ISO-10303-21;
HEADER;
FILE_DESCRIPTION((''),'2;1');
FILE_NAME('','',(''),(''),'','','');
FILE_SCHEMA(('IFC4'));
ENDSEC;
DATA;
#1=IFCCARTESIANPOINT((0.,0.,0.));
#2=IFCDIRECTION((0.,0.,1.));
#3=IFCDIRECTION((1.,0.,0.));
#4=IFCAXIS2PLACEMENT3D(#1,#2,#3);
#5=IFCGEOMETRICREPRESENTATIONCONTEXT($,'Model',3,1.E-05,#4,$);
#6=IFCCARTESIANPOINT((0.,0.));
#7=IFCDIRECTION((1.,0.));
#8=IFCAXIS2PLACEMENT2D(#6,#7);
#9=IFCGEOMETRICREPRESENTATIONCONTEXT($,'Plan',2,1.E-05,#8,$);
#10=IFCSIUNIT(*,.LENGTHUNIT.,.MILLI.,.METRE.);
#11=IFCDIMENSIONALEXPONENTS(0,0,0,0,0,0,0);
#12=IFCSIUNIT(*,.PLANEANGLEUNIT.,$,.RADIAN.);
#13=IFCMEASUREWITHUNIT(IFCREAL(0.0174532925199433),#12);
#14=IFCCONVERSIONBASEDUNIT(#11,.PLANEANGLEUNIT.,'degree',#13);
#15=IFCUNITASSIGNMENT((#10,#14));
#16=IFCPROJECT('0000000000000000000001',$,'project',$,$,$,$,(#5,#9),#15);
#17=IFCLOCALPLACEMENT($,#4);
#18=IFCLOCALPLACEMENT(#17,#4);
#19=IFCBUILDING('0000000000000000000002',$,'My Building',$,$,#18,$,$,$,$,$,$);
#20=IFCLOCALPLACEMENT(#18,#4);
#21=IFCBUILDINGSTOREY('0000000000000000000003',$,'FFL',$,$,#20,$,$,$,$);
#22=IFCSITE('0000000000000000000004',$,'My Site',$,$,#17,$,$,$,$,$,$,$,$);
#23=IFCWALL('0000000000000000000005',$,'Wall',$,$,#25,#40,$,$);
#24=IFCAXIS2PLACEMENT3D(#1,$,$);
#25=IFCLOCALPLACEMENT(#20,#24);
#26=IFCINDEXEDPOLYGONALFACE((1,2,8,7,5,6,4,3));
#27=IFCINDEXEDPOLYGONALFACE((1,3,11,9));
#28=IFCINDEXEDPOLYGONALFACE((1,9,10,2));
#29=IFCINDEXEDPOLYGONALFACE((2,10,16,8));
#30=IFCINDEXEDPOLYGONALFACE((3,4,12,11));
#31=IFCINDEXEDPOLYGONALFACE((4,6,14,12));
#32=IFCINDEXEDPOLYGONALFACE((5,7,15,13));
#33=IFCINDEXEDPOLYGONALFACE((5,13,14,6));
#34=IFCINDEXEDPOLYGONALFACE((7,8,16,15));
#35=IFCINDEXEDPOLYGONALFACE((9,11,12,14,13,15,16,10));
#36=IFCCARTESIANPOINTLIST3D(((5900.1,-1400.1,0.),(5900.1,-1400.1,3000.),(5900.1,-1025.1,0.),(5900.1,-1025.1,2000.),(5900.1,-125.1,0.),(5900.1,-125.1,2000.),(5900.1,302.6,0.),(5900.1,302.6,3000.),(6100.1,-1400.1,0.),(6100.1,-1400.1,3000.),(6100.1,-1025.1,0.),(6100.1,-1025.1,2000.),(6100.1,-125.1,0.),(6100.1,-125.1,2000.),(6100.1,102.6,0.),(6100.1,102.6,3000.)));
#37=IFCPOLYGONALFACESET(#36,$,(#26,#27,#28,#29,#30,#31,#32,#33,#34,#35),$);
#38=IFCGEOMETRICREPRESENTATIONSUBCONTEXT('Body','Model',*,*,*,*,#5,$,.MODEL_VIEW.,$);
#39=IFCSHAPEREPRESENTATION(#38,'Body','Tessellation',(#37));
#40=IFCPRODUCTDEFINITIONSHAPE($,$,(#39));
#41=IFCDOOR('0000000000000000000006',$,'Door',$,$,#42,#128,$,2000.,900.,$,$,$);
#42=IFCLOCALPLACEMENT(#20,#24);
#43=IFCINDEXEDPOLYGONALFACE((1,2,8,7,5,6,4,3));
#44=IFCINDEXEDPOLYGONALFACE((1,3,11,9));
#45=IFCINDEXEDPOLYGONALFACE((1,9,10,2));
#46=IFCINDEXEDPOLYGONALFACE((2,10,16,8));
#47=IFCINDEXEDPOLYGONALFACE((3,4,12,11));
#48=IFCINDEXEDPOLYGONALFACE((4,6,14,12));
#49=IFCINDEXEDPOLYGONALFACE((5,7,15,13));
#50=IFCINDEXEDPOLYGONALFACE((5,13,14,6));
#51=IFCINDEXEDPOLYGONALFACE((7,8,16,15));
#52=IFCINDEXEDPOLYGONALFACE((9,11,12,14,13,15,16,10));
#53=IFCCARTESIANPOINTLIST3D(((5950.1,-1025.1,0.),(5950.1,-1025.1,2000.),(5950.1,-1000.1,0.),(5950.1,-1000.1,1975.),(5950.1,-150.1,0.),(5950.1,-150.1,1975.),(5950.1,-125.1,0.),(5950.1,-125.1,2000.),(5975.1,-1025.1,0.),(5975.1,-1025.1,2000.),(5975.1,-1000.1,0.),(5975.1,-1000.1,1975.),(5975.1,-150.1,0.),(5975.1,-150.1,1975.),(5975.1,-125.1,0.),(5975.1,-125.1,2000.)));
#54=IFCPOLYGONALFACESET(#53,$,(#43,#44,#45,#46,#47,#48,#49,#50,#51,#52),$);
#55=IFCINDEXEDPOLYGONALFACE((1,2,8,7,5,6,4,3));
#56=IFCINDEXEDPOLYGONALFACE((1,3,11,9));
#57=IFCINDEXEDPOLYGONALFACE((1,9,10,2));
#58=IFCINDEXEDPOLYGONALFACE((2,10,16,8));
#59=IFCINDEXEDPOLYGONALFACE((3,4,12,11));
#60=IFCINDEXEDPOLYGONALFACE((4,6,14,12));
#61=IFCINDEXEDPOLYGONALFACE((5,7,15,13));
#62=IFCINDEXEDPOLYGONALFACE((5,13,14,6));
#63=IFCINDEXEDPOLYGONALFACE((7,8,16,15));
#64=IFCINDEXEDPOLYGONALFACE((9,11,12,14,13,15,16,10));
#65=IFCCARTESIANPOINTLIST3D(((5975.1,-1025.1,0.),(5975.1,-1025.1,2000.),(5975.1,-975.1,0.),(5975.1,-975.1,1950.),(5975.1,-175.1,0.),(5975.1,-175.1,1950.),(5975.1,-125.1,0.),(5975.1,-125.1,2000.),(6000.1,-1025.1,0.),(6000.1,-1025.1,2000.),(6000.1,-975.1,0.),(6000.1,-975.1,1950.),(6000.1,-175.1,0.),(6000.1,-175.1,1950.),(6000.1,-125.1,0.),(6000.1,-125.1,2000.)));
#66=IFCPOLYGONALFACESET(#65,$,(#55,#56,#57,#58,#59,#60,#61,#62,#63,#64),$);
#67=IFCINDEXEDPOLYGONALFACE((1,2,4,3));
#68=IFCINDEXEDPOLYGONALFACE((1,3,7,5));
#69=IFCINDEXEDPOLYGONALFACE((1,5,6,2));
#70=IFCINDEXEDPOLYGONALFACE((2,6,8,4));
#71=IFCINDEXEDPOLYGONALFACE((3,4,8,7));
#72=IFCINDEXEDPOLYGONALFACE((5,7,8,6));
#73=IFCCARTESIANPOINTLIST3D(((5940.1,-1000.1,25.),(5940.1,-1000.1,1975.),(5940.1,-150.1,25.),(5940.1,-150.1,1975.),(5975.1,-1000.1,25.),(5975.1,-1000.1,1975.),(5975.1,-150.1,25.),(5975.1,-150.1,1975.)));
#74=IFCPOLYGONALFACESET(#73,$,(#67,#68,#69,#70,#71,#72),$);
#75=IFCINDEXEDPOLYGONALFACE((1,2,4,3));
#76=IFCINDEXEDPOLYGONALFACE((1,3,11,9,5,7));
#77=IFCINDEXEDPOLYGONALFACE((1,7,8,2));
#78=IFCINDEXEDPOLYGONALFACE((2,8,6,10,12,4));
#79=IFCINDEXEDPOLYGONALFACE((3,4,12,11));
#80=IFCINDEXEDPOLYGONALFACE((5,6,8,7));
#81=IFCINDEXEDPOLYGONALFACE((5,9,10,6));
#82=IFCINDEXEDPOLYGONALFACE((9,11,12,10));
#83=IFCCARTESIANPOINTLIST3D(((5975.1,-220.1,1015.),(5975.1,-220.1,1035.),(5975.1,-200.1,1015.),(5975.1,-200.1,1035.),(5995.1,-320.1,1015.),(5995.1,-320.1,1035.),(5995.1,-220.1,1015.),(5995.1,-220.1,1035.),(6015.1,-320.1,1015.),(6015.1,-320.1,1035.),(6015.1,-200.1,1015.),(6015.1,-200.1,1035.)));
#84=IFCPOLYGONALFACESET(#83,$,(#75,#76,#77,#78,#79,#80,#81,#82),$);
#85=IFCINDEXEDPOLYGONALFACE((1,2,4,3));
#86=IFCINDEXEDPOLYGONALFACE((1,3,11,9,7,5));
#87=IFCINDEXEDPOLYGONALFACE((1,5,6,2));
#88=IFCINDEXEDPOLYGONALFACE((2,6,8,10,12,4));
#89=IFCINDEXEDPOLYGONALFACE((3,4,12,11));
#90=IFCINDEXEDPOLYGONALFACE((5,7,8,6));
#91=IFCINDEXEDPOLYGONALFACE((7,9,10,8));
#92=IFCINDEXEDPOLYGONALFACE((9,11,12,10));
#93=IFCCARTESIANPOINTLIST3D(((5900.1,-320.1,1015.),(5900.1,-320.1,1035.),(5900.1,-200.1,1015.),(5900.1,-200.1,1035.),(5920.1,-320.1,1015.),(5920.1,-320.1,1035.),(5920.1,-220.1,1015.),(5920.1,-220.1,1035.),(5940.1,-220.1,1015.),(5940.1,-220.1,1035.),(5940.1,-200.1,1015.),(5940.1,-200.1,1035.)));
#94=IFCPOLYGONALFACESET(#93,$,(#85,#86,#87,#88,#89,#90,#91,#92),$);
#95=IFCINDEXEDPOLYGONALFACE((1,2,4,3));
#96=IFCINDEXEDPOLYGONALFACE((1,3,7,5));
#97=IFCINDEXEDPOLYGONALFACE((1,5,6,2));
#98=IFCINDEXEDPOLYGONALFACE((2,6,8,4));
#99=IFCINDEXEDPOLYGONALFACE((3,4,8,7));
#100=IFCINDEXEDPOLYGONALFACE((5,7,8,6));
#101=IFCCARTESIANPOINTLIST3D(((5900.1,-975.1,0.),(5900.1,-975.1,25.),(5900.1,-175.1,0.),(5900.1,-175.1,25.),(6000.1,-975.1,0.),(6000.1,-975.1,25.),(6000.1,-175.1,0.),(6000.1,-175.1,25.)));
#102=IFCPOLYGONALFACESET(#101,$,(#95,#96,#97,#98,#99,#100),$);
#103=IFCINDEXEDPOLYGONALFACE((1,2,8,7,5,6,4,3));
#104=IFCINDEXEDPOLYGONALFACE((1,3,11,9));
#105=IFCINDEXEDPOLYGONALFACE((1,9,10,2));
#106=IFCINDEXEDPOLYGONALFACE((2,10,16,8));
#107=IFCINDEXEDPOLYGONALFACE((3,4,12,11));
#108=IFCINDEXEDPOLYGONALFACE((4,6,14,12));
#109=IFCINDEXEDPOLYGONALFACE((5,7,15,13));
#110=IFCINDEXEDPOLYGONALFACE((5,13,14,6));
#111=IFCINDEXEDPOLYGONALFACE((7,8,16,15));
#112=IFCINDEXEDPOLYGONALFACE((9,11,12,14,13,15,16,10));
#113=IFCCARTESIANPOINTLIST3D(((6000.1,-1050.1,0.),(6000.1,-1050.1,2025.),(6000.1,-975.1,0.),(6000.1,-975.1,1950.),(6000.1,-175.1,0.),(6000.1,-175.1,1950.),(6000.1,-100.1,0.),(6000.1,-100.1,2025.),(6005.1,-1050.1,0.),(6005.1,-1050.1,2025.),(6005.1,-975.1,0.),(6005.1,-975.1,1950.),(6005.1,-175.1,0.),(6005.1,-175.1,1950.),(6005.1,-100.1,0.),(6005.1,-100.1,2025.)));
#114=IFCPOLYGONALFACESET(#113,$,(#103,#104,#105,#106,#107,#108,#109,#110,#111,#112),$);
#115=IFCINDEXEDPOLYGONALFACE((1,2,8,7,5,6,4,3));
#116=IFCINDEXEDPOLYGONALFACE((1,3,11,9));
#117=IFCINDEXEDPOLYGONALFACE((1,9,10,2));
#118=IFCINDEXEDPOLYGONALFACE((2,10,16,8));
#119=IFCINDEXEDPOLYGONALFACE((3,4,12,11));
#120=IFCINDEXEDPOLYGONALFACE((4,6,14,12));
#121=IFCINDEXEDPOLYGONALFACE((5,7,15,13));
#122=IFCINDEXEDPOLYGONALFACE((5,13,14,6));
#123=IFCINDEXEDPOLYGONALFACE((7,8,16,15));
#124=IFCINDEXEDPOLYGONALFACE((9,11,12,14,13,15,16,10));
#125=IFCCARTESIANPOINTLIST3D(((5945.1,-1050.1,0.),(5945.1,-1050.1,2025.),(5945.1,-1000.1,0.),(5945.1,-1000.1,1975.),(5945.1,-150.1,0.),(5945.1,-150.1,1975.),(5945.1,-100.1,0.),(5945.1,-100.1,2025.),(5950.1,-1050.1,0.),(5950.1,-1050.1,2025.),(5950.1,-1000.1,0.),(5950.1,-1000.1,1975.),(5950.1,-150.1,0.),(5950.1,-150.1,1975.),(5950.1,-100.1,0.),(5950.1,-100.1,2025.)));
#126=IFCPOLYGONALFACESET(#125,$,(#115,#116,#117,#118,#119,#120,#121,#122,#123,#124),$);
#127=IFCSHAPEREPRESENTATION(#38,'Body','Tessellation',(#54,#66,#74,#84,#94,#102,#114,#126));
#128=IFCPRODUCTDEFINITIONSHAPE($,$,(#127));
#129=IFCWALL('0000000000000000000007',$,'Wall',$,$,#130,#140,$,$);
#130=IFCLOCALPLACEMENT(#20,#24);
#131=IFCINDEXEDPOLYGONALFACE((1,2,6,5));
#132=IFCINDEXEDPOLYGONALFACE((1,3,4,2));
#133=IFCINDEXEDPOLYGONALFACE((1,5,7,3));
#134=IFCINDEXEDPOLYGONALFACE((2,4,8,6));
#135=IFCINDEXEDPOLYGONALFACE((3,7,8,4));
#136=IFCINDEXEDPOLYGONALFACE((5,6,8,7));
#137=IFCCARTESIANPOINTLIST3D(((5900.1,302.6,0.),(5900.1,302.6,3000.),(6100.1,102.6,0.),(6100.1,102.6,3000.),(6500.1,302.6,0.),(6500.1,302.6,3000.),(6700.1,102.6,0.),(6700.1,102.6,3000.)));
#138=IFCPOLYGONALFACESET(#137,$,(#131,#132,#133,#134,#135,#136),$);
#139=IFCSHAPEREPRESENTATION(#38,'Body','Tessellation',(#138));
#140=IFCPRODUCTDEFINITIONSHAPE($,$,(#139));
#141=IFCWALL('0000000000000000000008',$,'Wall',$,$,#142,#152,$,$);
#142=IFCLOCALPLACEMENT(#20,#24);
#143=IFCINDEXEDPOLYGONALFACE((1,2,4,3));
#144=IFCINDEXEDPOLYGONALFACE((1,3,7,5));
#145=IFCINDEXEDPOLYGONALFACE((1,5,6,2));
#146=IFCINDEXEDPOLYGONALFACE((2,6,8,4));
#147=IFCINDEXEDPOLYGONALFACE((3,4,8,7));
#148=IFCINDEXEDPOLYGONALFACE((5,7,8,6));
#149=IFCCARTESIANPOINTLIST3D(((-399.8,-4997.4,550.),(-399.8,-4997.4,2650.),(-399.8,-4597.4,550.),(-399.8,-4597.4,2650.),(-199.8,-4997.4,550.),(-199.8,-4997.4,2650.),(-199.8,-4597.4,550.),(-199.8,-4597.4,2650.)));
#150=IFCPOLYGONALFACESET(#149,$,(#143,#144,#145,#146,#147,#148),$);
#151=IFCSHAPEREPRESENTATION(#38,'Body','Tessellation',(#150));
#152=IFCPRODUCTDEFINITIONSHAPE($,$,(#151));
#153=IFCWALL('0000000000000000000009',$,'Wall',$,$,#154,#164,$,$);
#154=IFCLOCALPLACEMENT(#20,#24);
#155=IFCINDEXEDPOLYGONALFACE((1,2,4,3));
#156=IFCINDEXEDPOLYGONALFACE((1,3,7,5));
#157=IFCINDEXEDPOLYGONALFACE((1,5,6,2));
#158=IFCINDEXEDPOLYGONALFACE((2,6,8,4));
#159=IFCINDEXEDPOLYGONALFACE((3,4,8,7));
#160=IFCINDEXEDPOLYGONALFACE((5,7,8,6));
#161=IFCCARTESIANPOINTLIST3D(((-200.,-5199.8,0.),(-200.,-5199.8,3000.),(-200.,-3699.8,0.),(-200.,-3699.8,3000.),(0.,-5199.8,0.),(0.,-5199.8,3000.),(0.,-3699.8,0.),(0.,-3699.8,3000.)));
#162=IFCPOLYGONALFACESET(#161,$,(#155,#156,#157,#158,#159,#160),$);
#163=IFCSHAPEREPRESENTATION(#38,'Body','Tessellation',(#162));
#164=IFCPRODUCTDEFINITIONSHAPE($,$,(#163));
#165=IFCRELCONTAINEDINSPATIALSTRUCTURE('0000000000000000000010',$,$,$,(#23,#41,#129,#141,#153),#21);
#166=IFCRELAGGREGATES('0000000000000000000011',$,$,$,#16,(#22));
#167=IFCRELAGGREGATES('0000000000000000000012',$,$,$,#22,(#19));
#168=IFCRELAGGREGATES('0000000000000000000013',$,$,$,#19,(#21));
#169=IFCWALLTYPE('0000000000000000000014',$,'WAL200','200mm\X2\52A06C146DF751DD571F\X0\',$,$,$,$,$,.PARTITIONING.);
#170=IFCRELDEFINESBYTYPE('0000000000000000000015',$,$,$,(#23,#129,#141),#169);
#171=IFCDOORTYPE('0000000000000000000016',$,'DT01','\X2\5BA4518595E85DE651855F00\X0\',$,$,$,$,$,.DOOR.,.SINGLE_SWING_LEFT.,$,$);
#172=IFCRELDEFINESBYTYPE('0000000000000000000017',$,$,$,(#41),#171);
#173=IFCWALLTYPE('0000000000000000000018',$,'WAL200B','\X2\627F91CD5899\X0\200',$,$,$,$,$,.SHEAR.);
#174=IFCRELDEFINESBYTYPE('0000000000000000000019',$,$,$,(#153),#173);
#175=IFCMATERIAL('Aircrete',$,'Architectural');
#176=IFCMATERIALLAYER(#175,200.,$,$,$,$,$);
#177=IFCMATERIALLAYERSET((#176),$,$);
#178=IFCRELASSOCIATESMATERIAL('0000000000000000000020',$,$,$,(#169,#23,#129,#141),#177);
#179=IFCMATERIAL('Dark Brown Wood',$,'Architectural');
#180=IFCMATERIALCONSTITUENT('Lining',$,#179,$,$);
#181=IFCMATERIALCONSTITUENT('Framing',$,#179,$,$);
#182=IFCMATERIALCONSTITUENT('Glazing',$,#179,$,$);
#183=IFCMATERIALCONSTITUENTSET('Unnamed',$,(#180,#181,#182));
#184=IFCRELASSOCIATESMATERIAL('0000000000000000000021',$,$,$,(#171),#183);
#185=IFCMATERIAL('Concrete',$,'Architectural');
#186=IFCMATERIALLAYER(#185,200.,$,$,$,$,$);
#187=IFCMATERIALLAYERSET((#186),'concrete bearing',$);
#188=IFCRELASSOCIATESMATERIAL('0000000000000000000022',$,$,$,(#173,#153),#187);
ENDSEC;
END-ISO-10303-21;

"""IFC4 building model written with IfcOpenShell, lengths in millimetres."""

from ifc_helpers import new_model, entity, si_unit, converted_unit, frame, origin_with_axes, origin_2d_with_axis, place, context, subcontext, project, spatial, line, indexed_curve, outline, extrude, shape, source, transform, mapped, material, layer, layer_set, layer_usage, constituent, constituent_set, type_object, type_shapes, element, fill, save


model = new_model("IFC4")

# Units and contexts
model_context = context("Model", 3, precision=1e-05, world=origin_with_axes())
plan_context = context("Plan", 2, precision=1e-05, world=origin_2d_with_axis())
body_context_1 = subcontext(model_context, "Body", "Model", "MODEL_VIEW")
body_context_2 = subcontext(plan_context, "Body", "Plan", "PLAN_VIEW")
ifc_project = project(units=[si_unit("LENGTHUNIT", "METRE", prefix="MILLI"), converted_unit("PLANEANGLEUNIT", "degree", entity("IfcReal", 0.0174532925199433), si_unit("PLANEANGLEUNIT", "RADIAN"), dimensions=[0, 0, 0, 0, 0, 0, 0])], contexts=[model_context, plan_context])

# Site, building, storey
site_placement = place(None, origin_with_axes())
site = spatial("IfcSite", under=ifc_project, at=site_placement, Name="My Site")
building_placement = place(site_placement, origin_with_axes())
building = spatial("IfcBuilding", under=site, at=building_placement, Name="My Building")
storey_placement = place(building_placement, origin_with_axes())
storey = spatial("IfcBuildingStorey", under=building, at=storey_placement, Name="FFL")

# Shared definitions
ifc_material_1 = material(Name="Aircrete", Category="Architectural")

# Shared definitions
ifc_layer_1 = layer(ifc_material_1, 200.0)
ifc_layer_set_1 = layer_set([ifc_layer_1])
wall_type_1 = type_object("IfcWallType", Name="WAL200", Description="200mm加气混凝土", PredefinedType="PARTITIONING", material=ifc_layer_set_1)

# Wall, opening, door
ifc_layer_usage_1 = layer_usage(ifc_layer_set_1, "AXIS2", "NEGATIVE", 0.0)
wall_1_placement = place(storey_placement, frame((5900.1, -1400.1, 0.0), z_axis=(0.0, 0.0, 1.0), x_axis=(0.0, 1.0, 0.0)))
wall_1 = element("IfcWall", 1, at=wall_1_placement, inside=storey, type_object=wall_type_1, material=ifc_layer_usage_1, Name="Wall", context=body_context_1, shape_type="SweptSolid", body=[
    extrude(outline(indexed_curve([(0.0, -200.0), (0.0, 0.0), (1702.7, 0.0), (1502.7, -200.0)], segments=[line(1, 2, 3, 4, 1)])), origin_with_axes(), (0.0, 0.0, 1.0), 3000.0),
])
shared_shape_1 = source(origin_with_axes(), body_context_1, "Body", "SweptSolid", [
    extrude(outline(indexed_curve([(0.0, 0.0), (900.0, 0.0), (900.0, 2000.0), (0.0, 2000.0)], segments=[line(1, 2, 3, 4, 1)])), frame((0.0, -600.0, 0.0), z_axis=(0.0, -1.0, 0.0), x_axis=(1.0, 0.0, 0.0)), (0.0, 0.0, -1.0), 1200.0),
])
opening_1_placement = place(wall_1_placement, frame((375.0, -100.0, 0.0), z_axis=(0.0, 0.0, 1.0), x_axis=(1.0, 0.0, 0.0)))
opening_1 = element("IfcOpeningElement", 2, at=opening_1_placement, cuts=wall_1, PredefinedType="OPENING", context=body_context_1, shape_type="MappedRepresentation", body=[
    mapped(shared_shape_1, transform((0.0, 0.0, 0.0), x_axis=(1.0, 0.0, 0.0), y_axis=(0.0, 1.0, 0.0), z_axis=(0.0, 0.0, 1.0), scale=1.0)),
])
ifc_material_2 = material(Name="Dark Brown Wood", Category="Architectural")
ifc_constituent_1 = constituent(ifc_material_2, Name="Lining")
ifc_constituent_2 = constituent(ifc_material_2, Name="Framing")
ifc_constituent_3 = constituent(ifc_material_2, Name="Glazing")
ifc_constituent_set_1 = constituent_set(constituents=[ifc_constituent_1, ifc_constituent_2, ifc_constituent_3], Name="Unnamed")
door_type = type_object("IfcDoorType", Name="DT01", Description="室内门左内开", OperationType="SINGLE_SWING_LEFT", PredefinedType="DOOR", material=ifc_constituent_set_1)
shared_shape_2 = source(origin_with_axes(), body_context_1, "Body", "SweptSolid", [
    extrude(outline(indexed_curve([(0.0, 0.0), (0.0, 2000.0), (900.0, 2000.0), (900.0, 0.0), (875.0, 0.0), (875.0, 1975.0), (25.0, 1975.0), (25.0, 0.0)], segments=[line(1, 2, 3, 4, 5, 6, 7, 8, 1)])), frame((0.0, 25.0, 0.0), z_axis=(0.0, -1.0, 0.0), x_axis=(1.0, 0.0, 0.0)), (0.0, 0.0, -1.0), 25.0),
    extrude(outline(indexed_curve([(0.0, 0.0), (0.0, 2000.0), (900.0, 2000.0), (900.0, 0.0), (850.0, 0.0), (850.0, 1950.0), (50.0, 1950.0), (50.0, 0.0)], segments=[line(1, 2, 3, 4, 5, 6, 7, 8, 1)])), frame((0.0, 0.0, 0.0), z_axis=(0.0, -1.0, 0.0), x_axis=(1.0, 0.0, 0.0)), (0.0, 0.0, -1.0), 25.0),
    extrude(outline(indexed_curve([(0.0, 0.0), (850.0, 0.0), (850.0, 35.0), (0.0, 35.0)], segments=[line(1, 2, 3, 4, 1)])), frame((25.0, 25.0, 25.0), z_axis=(0.0, 0.0, 1.0), x_axis=(1.0, 0.0, 0.0)), (0.0, 0.0, 1.0), 1950.0),
    extrude(outline(indexed_curve([(0.0, 0.0), (0.0, -40.0), (-120.0, -40.0), (-120.0, -20.0), (-20.0, -20.0), (-20.0, 0.0)], segments=[line(1, 2, 3, 4, 5, 6, 1)])), frame((825.0, 25.0, 1015.0), z_axis=(0.0, 0.0, 1.0), x_axis=(1.0, 0.0, 0.0)), (0.0, 0.0, 1.0), 20.0),
    extrude(outline(indexed_curve([(0.0, 0.0), (0.0, 40.0), (-120.0, 40.0), (-120.0, 20.0), (-20.0, 20.0), (-20.0, 0.0)], segments=[line(1, 2, 3, 4, 5, 6, 1)])), frame((825.0, 60.0, 1015.0), z_axis=(0.0, 0.0, 1.0), x_axis=(1.0, 0.0, 0.0)), (0.0, 0.0, 1.0), 20.0),
    extrude(outline(indexed_curve([(0.0, 0.0), (800.0, 0.0), (800.0, 100.0), (0.0, 100.0)], segments=[line(1, 2, 3, 4, 1)])), frame((50.0, 0.0, 0.0), z_axis=(0.0, 0.0, 1.0), x_axis=(1.0, 0.0, 0.0)), (0.0, 0.0, 1.0), 25.0),
    extrude(outline(indexed_curve([(0.0, 0.0), (0.0, 2025.0), (950.0, 2025.0), (950.0, 0.0), (875.0, 0.0), (875.0, 1950.0), (75.0, 1950.0), (75.0, 0.0)], segments=[line(1, 2, 3, 4, 5, 6, 7, 8, 1)])), frame((-25.0, -5.0, 0.0), z_axis=(0.0, -1.0, 0.0), x_axis=(1.0, 0.0, 0.0)), (0.0, 0.0, -1.0), 5.0),
    extrude(outline(indexed_curve([(0.0, 0.0), (0.0, 2025.0), (950.0, 2025.0), (950.0, 0.0), (900.0, 0.0), (900.0, 1975.0), (50.0, 1975.0), (50.0, 0.0)], segments=[line(1, 2, 3, 4, 5, 6, 7, 8, 1)])), frame((-25.0, 50.0, 0.0), z_axis=(0.0, -1.0, 0.0), x_axis=(1.0, 0.0, 0.0)), (0.0, 0.0, -1.0), 5.0),
])
shared_shape_3 = source(origin_with_axes(), body_context_2, "Body", "Curve2D", [
    entity("IfcIndexedPolyCurve", entity("IfcCartesianPointList2D", [[0.0, 0.0], [0.0, 50.0], [25.0, 50.0], [25.0, 25.0], [50.0, 25.0], [50.0, 0.0]]), [entity("IfcLineIndex", [1, 2, 3, 4, 5, 6, 1])]),
    entity("IfcIndexedPolyCurve", entity("IfcCartesianPointList2D", [[900.0, 0.0], [900.0, 50.0], [875.0, 50.0], [875.0, 25.0], [850.0, 25.0], [850.0, 0.0]]), [entity("IfcLineIndex", [1, 2, 3, 4, 5, 6, 1])]),
    entity("IfcTrimmedCurve", entity("IfcEllipse", entity("IfcAxis2Placement2D", entity("IfcCartesianPoint", [60.0, 50.0]), entity("IfcDirection", [1.0, 0.0])), 815.0, 850.0), [entity("IfcCartesianPoint", [875.0, 50.0])], [entity("IfcCartesianPoint", [60.0, 900.0])], True, "CARTESIAN"),
    entity("IfcIndexedPolyCurve", entity("IfcCartesianPointList2D", [[25.0, 50.0], [60.0, 50.0], [60.0, 900.0], [25.0, 900.0]]), [entity("IfcLineIndex", [1, 2, 3, 4, 1])]),
])
type_shapes(door_type, [shared_shape_2, shared_shape_3])
door_placement = place(opening_1_placement, frame((0.0, 0.0, 0.0), z_axis=(0.0, 0.0, 1.0), x_axis=(1.0, 0.0, 0.0)))
door = element("IfcDoor", 3, at=door_placement, inside=storey, type_object=door_type, Name="Door", OverallHeight=2000.0, OverallWidth=900.0, shapes=[
    shape(body_context_1, "Body", "MappedRepresentation", [mapped(shared_shape_2, transform((0.0, 0.0, 0.0), x_axis=(1.0, 0.0, 0.0), y_axis=(0.0, 1.0, 0.0), z_axis=(0.0, 0.0, 1.0), scale=1.0))]),
    shape(body_context_2, "Body", "MappedRepresentation", [mapped(shared_shape_3, transform((0.0, 0.0, 0.0), x_axis=(1.0, 0.0, 0.0), y_axis=(0.0, 1.0, 0.0), z_axis=(0.0, 0.0, 1.0), scale=1.0))]),
])
fill(opening_1, door)

# Walls
ifc_layer_usage_2 = layer_usage(ifc_layer_set_1, "AXIS2", "NEGATIVE", 0.0)
wall_2_placement = place(storey_placement, frame((5900.1, 302.6, 0.0), z_axis=(0.0, 0.0, 1.0), x_axis=(1.0, 0.0, 0.0)))
element("IfcWall", 4, at=wall_2_placement, inside=storey, type_object=wall_type_1, material=ifc_layer_usage_2, Name="Wall", context=body_context_1, shape_type="SweptSolid", body=[
    extrude(outline(indexed_curve([(200.0, -200.0), (0.0, 0.0), (600.0, 0.0), (800.0, -200.0)], segments=[line(1, 2, 3, 4, 1)])), origin_with_axes(), (0.0, 0.0, 1.0), 3000.0),
])
ifc_layer_usage_3 = layer_usage(ifc_layer_set_1, "AXIS2", "NEGATIVE", 0.0)
wall_3_placement = place(storey_placement, frame((-399.8, -4997.4, 550.0), z_axis=(0.0, 0.0, 1.0), x_axis=(0.0, 1.0, 0.0)))
element("IfcWall", 5, at=wall_3_placement, inside=storey, type_object=wall_type_1, material=ifc_layer_usage_3, Name="Wall", context=body_context_1, shape_type="SweptSolid", body=[
    extrude(outline(indexed_curve([(0.0, -200.0), (0.0, 0.0), (400.0, 0.0), (400.0, -200.0)], segments=[line(1, 2, 3, 4, 1)])), origin_with_axes(), (0.0, 0.0, 1.0), 2100.0),
])

# Wall
ifc_material_3 = material(Name="Concrete", Category="Architectural")
ifc_layer_2 = layer(ifc_material_3, 200.0)
ifc_layer_set_2 = layer_set([ifc_layer_2], Name="concrete bearing")
ifc_layer_usage_4 = layer_usage(ifc_layer_set_2, "AXIS2", "NEGATIVE", 0.0)
wall_type_2 = type_object("IfcWallType", Name="WAL200B", Description="承重墙200", PredefinedType="SHEAR", material=ifc_layer_set_2)
wall_4_placement = place(storey_placement, frame((-200.0, -5199.8, 0.0), z_axis=(0.0, 0.0, 1.0), x_axis=(-0.000008, 1.0, 0.0)))
element("IfcWall", 6, at=wall_4_placement, inside=storey, type_object=wall_type_2, material=ifc_layer_usage_4, Name="Wall", context=body_context_1, shape_type="SweptSolid", body=[
    extrude(outline(indexed_curve([(0.0, -200.0), (0.0, 0.0), (1500.0, 0.0), (1500.0, -200.0)], segments=[line(1, 2, 3, 4, 1)])), origin_with_axes(), (0.0, 0.0, 1.0), 3000.0),
])

save(model, "model.ifc")
